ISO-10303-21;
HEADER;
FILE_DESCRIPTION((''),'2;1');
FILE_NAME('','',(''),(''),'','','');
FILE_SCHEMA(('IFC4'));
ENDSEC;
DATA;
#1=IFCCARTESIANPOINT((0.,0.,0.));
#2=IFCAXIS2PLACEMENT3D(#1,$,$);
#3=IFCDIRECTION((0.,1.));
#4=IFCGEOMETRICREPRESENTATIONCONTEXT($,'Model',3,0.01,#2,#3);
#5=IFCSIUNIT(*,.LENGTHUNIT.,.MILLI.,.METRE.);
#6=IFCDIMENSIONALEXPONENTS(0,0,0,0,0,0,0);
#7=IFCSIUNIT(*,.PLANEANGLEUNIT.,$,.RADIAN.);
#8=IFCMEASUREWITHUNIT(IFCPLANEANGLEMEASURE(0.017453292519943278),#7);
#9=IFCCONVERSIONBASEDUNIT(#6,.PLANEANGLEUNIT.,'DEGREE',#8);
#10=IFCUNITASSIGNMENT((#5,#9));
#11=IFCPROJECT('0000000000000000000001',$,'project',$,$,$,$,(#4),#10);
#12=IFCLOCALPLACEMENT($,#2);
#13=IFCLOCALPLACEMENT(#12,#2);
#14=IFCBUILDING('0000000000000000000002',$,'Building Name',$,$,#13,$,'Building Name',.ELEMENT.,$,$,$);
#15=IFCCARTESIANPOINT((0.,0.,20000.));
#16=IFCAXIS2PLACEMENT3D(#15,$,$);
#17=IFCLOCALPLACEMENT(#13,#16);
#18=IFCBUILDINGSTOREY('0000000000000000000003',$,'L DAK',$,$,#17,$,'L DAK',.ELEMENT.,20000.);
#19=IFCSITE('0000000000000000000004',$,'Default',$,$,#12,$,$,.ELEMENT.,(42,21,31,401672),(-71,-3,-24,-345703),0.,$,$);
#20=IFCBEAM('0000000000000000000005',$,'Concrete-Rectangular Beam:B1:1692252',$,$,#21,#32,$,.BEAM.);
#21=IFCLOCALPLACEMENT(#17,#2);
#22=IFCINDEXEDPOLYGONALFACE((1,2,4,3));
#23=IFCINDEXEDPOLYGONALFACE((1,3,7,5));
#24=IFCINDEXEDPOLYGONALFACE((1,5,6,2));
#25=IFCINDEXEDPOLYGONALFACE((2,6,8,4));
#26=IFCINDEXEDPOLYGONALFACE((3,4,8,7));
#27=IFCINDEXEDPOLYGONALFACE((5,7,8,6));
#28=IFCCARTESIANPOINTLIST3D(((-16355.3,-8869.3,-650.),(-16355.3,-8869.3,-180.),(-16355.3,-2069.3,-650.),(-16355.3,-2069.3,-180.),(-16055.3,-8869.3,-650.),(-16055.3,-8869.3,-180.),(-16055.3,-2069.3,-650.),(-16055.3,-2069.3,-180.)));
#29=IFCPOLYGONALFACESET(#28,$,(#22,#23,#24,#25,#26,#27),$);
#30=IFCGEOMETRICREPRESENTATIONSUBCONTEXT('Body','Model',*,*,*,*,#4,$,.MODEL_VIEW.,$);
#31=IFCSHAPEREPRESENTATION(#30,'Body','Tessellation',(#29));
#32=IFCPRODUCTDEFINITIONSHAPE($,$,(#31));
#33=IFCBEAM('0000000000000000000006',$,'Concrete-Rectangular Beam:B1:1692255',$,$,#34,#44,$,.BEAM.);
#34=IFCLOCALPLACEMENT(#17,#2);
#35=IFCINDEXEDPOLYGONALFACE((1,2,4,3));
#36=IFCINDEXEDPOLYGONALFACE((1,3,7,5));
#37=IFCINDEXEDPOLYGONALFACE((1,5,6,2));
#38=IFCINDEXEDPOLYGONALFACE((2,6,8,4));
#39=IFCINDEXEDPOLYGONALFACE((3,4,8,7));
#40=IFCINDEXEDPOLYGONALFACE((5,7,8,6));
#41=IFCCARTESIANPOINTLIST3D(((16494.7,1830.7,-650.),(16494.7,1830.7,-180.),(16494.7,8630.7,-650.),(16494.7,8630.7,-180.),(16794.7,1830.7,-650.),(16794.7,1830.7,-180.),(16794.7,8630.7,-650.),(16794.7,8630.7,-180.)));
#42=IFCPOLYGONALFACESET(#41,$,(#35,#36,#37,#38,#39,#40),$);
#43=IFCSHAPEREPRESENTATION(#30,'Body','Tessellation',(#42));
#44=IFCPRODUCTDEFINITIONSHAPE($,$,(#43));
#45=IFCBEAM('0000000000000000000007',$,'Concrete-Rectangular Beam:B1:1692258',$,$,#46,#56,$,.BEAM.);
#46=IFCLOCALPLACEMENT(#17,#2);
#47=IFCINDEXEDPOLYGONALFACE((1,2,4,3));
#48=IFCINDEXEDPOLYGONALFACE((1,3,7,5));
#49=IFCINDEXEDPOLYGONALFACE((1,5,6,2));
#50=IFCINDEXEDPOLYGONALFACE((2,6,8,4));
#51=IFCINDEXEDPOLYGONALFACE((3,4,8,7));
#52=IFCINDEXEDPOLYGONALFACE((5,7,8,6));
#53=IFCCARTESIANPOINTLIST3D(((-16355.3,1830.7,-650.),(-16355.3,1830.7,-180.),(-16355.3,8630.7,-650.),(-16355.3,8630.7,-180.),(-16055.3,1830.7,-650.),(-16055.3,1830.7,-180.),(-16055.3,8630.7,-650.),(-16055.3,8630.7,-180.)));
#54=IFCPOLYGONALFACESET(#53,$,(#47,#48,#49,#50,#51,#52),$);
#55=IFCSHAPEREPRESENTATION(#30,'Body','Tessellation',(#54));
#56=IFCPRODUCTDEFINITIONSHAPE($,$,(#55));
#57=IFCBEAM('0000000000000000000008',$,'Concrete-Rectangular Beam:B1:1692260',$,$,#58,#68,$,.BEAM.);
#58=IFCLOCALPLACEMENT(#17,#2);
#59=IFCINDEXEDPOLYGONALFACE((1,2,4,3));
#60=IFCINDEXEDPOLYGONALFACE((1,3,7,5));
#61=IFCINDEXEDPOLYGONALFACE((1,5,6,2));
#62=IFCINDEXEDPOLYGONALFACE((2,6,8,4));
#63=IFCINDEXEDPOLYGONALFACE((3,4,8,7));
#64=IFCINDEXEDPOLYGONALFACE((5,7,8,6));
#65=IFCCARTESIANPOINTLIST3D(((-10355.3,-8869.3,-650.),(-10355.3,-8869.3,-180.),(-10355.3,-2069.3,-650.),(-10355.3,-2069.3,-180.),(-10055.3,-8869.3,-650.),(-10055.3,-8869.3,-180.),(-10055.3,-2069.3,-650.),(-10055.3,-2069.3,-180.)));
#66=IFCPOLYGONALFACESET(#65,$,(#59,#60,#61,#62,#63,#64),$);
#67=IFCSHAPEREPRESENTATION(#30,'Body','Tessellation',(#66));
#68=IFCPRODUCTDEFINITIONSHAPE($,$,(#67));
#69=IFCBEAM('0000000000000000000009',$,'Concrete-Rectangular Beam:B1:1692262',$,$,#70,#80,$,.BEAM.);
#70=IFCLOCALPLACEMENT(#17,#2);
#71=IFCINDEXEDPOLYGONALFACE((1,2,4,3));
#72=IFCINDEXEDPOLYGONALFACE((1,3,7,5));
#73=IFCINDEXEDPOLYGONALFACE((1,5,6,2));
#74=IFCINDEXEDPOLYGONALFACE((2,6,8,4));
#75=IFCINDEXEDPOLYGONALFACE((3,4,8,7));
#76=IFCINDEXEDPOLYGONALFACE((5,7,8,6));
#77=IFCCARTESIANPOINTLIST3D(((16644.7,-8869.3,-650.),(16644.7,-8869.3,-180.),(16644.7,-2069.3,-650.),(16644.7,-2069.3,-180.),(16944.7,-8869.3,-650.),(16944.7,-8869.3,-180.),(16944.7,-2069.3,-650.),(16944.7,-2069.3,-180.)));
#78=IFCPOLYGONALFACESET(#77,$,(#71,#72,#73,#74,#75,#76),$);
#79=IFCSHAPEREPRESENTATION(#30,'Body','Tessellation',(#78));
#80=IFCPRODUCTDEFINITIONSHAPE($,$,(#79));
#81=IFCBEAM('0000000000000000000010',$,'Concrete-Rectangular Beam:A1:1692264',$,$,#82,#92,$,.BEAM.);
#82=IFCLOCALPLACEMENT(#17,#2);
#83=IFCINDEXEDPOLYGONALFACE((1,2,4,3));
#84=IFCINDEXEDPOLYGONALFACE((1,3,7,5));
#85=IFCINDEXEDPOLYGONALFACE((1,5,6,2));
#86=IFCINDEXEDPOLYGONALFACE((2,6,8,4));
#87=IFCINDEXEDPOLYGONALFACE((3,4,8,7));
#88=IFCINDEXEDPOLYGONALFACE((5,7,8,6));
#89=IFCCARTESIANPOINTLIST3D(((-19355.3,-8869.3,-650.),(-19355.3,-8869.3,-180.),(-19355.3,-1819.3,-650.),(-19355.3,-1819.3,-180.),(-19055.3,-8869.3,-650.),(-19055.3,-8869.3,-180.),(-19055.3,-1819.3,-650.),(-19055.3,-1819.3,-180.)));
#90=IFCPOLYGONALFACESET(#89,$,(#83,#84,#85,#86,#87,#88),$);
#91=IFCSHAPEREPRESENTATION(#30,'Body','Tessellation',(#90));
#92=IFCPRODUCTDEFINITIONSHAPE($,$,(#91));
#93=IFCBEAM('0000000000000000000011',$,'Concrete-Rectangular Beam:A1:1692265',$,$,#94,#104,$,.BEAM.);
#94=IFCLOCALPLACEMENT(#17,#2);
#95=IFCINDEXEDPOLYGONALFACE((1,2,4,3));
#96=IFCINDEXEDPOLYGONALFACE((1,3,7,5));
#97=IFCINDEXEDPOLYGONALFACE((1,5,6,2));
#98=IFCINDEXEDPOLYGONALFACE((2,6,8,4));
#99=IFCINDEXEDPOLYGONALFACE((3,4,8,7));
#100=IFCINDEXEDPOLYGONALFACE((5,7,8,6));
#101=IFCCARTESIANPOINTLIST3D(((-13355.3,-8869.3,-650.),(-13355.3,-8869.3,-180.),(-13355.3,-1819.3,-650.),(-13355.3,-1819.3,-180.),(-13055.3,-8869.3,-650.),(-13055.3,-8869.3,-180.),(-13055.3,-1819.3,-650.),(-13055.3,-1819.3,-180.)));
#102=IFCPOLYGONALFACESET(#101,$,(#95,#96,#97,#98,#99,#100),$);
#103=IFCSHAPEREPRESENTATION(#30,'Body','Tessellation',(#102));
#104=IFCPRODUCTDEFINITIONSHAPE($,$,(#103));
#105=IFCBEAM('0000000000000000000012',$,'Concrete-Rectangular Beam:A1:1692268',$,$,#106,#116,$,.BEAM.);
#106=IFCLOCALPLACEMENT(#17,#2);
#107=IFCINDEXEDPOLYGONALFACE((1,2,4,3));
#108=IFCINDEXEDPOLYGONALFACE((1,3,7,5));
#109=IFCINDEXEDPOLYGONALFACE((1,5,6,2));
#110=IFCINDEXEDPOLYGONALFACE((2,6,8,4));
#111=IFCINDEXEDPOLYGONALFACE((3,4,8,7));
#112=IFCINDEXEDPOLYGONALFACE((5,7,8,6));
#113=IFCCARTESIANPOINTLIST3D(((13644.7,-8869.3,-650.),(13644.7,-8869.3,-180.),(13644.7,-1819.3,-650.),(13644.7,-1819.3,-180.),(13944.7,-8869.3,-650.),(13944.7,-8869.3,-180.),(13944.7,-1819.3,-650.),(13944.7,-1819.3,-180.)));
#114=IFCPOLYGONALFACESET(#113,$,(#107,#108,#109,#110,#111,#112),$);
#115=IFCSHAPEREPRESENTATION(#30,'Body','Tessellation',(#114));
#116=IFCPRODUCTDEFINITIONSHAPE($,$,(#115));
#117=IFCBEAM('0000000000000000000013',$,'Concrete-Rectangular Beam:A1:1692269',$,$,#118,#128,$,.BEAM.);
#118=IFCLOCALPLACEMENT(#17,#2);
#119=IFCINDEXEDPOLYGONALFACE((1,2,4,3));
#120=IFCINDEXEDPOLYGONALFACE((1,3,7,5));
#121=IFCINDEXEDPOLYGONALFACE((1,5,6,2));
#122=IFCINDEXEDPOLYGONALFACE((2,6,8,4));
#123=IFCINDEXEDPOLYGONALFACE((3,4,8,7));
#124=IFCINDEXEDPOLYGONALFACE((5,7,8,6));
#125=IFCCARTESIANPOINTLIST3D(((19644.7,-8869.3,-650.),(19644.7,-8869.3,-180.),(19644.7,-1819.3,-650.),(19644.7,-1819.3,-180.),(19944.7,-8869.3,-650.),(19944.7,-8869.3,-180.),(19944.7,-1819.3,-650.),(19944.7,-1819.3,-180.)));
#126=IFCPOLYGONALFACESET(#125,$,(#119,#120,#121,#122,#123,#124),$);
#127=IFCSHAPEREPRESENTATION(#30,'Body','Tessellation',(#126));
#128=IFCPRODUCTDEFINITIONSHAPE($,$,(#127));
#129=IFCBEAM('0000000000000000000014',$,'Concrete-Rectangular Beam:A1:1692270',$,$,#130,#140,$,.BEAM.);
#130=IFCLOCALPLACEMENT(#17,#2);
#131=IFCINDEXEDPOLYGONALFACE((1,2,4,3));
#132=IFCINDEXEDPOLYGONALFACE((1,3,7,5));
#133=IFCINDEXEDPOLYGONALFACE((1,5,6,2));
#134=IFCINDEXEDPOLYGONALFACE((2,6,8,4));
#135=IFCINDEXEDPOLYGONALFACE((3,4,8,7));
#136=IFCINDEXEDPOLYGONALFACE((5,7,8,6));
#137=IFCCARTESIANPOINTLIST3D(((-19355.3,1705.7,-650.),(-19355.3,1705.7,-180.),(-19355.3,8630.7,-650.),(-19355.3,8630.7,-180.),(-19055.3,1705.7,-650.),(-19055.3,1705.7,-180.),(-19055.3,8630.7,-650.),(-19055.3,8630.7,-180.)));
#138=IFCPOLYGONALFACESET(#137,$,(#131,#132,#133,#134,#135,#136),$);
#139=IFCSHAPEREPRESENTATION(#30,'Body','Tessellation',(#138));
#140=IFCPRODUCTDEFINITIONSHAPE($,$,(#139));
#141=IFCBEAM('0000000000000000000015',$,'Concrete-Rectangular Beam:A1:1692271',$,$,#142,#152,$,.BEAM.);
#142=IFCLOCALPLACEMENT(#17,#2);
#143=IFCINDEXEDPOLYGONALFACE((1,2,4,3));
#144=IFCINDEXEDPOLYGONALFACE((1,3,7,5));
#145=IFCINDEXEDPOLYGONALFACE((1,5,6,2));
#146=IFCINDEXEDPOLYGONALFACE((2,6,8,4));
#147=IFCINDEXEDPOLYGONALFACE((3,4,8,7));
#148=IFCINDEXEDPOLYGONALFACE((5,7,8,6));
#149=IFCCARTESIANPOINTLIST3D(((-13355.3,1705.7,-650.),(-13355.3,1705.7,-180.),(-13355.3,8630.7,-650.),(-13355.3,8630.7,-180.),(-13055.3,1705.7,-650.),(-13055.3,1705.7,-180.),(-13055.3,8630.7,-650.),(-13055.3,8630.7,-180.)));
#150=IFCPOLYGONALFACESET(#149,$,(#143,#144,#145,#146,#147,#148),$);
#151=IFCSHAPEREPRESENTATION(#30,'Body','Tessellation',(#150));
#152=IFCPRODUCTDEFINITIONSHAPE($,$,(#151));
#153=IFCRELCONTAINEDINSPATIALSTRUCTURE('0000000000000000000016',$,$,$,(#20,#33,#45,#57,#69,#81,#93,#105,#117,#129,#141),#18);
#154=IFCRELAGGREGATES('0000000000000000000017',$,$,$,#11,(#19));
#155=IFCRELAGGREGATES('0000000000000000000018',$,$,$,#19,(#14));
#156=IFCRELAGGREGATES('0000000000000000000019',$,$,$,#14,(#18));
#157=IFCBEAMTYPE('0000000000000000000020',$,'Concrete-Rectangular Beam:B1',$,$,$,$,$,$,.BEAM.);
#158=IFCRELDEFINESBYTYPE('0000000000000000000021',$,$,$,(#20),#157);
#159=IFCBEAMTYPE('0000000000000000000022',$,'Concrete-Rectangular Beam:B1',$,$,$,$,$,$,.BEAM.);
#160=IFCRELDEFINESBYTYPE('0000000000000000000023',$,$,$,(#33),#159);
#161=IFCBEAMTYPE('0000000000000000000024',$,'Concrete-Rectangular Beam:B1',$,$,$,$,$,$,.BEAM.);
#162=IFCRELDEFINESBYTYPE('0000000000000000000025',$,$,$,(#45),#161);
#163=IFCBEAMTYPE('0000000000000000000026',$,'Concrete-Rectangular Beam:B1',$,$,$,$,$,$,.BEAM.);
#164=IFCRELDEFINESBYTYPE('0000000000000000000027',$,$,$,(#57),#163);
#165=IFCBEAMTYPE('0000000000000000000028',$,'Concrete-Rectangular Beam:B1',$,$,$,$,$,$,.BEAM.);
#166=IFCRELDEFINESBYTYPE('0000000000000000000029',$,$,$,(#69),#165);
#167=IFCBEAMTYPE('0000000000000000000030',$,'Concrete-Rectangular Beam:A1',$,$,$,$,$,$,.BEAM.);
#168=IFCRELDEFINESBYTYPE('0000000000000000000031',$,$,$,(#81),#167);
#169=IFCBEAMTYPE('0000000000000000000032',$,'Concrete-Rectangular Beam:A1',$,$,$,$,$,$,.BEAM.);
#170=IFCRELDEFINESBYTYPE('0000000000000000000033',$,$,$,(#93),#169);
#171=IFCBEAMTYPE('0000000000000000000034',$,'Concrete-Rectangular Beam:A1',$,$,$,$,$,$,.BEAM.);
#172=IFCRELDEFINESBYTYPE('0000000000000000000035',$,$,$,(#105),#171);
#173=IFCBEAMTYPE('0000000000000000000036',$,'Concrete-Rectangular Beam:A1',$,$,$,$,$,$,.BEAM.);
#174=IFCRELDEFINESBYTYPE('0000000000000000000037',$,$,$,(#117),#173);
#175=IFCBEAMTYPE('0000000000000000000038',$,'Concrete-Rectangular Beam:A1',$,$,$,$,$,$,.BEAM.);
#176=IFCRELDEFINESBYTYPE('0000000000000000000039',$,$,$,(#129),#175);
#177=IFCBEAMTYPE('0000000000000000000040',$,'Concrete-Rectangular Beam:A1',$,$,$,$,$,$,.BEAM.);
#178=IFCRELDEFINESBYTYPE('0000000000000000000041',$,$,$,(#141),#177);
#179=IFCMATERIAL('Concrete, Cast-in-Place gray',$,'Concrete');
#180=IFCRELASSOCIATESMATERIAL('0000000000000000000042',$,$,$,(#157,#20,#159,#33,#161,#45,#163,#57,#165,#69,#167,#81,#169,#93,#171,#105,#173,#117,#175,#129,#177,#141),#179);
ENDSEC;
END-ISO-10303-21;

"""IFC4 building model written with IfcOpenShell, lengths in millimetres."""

from ifc_helpers import new_model, entity, si_unit, converted_unit, direction, frame, origin, place, context, subcontext, project, spatial, indexed_curve, outline, extrude, source, transform, mapped, material, type_object, type_shapes, element, save


model = new_model("IFC4")

# Units and contexts
model_context = context("Model", 3, precision=0.01, world=origin(), true_north=direction((0.0, 1.0)))
body_context = subcontext(model_context, "Body", "Model", "MODEL_VIEW")
ifc_project = project(units=[si_unit("LENGTHUNIT", "METRE", prefix="MILLI"), converted_unit("PLANEANGLEUNIT", "DEGREE", entity("IfcPlaneAngleMeasure", 0.017453292519943278), si_unit("PLANEANGLEUNIT", "RADIAN"), dimensions=[0, 0, 0, 0, 0, 0, 0])], contexts=[model_context])

# Site, building, storey
site_placement = place(None, origin())
site = spatial("IfcSite", under=ifc_project, at=site_placement, Name="Default", CompositionType="ELEMENT", RefLatitude=(42, 21, 31, 401672), RefLongitude=(-71, -3, -24, -345703), RefElevation=0.0)
building_placement = place(site_placement, origin())
building = spatial("IfcBuilding", under=site, at=building_placement, Name="Building Name", LongName="Building Name", CompositionType="ELEMENT")
storey_placement = place(building_placement, frame((0.0, 0.0, 20000.0)))
storey = spatial("IfcBuildingStorey", under=building, at=storey_placement, Name="L DAK", LongName="L DAK", CompositionType="ELEMENT", Elevation=20000.0)

# Beams
ifc_material = material(Name="Concrete, Cast-in-Place gray", Category="Concrete")
beam_type_1 = type_object("IfcBeamType", Name="Concrete-Rectangular Beam:B1", PredefinedType="BEAM", material=ifc_material)
shared_shape_1 = source(origin(), body_context, "Body", "SweptSolid", [
    extrude(outline(indexed_curve([(-150.0, -235.0), (150.0, -235.0), (150.0, 235.0), (-150.0, 235.0), (-150.0, -235.0)], self_intersect=False)), frame((-16205.3, -2069.3, 19585.0), z_axis=(0.0, -1.0, 0.0), x_axis=(-1.0, 0.0, 0.0)), (0.0, 0.0, 1.0), 6800.0),
])
type_shapes(beam_type_1, [shared_shape_1])
beam_1_placement = place(storey_placement, frame((0.0, 0.0, -20000.0)))
element("IfcBeam", 1, at=beam_1_placement, inside=storey, type_object=beam_type_1, material=ifc_material, Name="Concrete-Rectangular Beam:B1:1692252", PredefinedType="BEAM", context=body_context, shape_type="MappedRepresentation", body=[
    mapped(shared_shape_1, transform((0.0, 0.0, 0.0), scale=1.0)),
])
beam_type_2 = type_object("IfcBeamType", Name="Concrete-Rectangular Beam:B1", PredefinedType="BEAM", material=ifc_material)
shared_shape_2 = source(origin(), body_context, "Body", "SweptSolid", [
    extrude(outline(indexed_curve([(-150.0, -235.0), (150.0, -235.0), (150.0, 235.0), (-150.0, 235.0), (-150.0, -235.0)], self_intersect=False)), frame((16644.7, 8630.7, 19585.0), z_axis=(0.0, -1.0, 0.0), x_axis=(-1.0, 0.0, 0.0)), (0.0, 0.0, 1.0), 6800.0),
])
type_shapes(beam_type_2, [shared_shape_2])
beam_2_placement = place(storey_placement, frame((0.0, 0.0, -20000.0)))
element("IfcBeam", 2, at=beam_2_placement, inside=storey, type_object=beam_type_2, material=ifc_material, Name="Concrete-Rectangular Beam:B1:1692255", PredefinedType="BEAM", context=body_context, shape_type="MappedRepresentation", body=[
    mapped(shared_shape_2, transform((0.0, 0.0, 0.0), scale=1.0)),
])
beam_type_3 = type_object("IfcBeamType", Name="Concrete-Rectangular Beam:B1", PredefinedType="BEAM", material=ifc_material)
shared_shape_3 = source(origin(), body_context, "Body", "SweptSolid", [
    extrude(outline(indexed_curve([(-150.0, -235.0), (150.0, -235.0), (150.0, 235.0), (-150.0, 235.0), (-150.0, -235.0)], self_intersect=False)), frame((-16205.3, 8630.7, 19585.0), z_axis=(0.0, -1.0, 0.0), x_axis=(-1.0, 0.0, 0.0)), (0.0, 0.0, 1.0), 6800.0),
])
type_shapes(beam_type_3, [shared_shape_3])
beam_3_placement = place(storey_placement, frame((0.0, 0.0, -20000.0)))
element("IfcBeam", 3, at=beam_3_placement, inside=storey, type_object=beam_type_3, material=ifc_material, Name="Concrete-Rectangular Beam:B1:1692258", PredefinedType="BEAM", context=body_context, shape_type="MappedRepresentation", body=[
    mapped(shared_shape_3, transform((0.0, 0.0, 0.0), scale=1.0)),
])
beam_type_4 = type_object("IfcBeamType", Name="Concrete-Rectangular Beam:B1", PredefinedType="BEAM", material=ifc_material)
shared_shape_4 = source(origin(), body_context, "Body", "SweptSolid", [
    extrude(outline(indexed_curve([(-150.0, -235.0), (150.0, -235.0), (150.0, 235.0), (-150.0, 235.0), (-150.0, -235.0)], self_intersect=False)), frame((-10205.3, -8869.3, 19585.0), z_axis=(0.0, 1.0, 0.0), x_axis=(-1.0, 0.0, 0.0)), (0.0, 0.0, 1.0), 6800.0),
])
type_shapes(beam_type_4, [shared_shape_4])
beam_4_placement = place(storey_placement, frame((0.0, 0.0, -20000.0)))
element("IfcBeam", 4, at=beam_4_placement, inside=storey, type_object=beam_type_4, material=ifc_material, Name="Concrete-Rectangular Beam:B1:1692260", PredefinedType="BEAM", context=body_context, shape_type="MappedRepresentation", body=[
    mapped(shared_shape_4, transform((0.0, 0.0, 0.0), scale=1.0)),
])
beam_type_5 = type_object("IfcBeamType", Name="Concrete-Rectangular Beam:B1", PredefinedType="BEAM", material=ifc_material)
shared_shape_5 = source(origin(), body_context, "Body", "SweptSolid", [
    extrude(outline(indexed_curve([(-150.0, -235.0), (150.0, -235.0), (150.0, 235.0), (-150.0, 235.0), (-150.0, -235.0)], self_intersect=False)), frame((16794.7, -8869.3, 19585.0), z_axis=(0.0, 1.0, 0.0), x_axis=(-1.0, 0.0, 0.0)), (0.0, 0.0, 1.0), 6800.0),
])
type_shapes(beam_type_5, [shared_shape_5])
beam_5_placement = place(storey_placement, frame((0.0, 0.0, -20000.0)))
element("IfcBeam", 5, at=beam_5_placement, inside=storey, type_object=beam_type_5, material=ifc_material, Name="Concrete-Rectangular Beam:B1:1692262", PredefinedType="BEAM", context=body_context, shape_type="MappedRepresentation", body=[
    mapped(shared_shape_5, transform((0.0, 0.0, 0.0), scale=1.0)),
])
beam_type_6 = type_object("IfcBeamType", Name="Concrete-Rectangular Beam:A1", PredefinedType="BEAM", material=ifc_material)
shared_shape_6 = source(origin(), body_context, "Body", "SweptSolid", [
    extrude(outline(indexed_curve([(-150.0, -235.0), (150.0, -235.0), (150.0, 235.0), (-150.0, 235.0), (-150.0, -235.0)], self_intersect=False)), frame((-19205.3, -8869.3, 19585.0), z_axis=(0.0, 1.0, 0.0), x_axis=(-1.0, 0.0, 0.0)), (0.0, 0.0, 1.0), 7050.0),
])
type_shapes(beam_type_6, [shared_shape_6])
beam_6_placement = place(storey_placement, frame((0.0, 0.0, -20000.0)))
element("IfcBeam", 6, at=beam_6_placement, inside=storey, type_object=beam_type_6, material=ifc_material, Name="Concrete-Rectangular Beam:A1:1692264", PredefinedType="BEAM", context=body_context, shape_type="MappedRepresentation", body=[
    mapped(shared_shape_6, transform((0.0, 0.0, 0.0), scale=1.0)),
])
beam_type_7 = type_object("IfcBeamType", Name="Concrete-Rectangular Beam:A1", PredefinedType="BEAM", material=ifc_material)
shared_shape_7 = source(origin(), body_context, "Body", "SweptSolid", [
    extrude(outline(indexed_curve([(-150.0, -235.0), (150.0, -235.0), (150.0, 235.0), (-150.0, 235.0), (-150.0, -235.0)], self_intersect=False)), frame((-13205.3, -8869.3, 19585.0), z_axis=(0.0, 1.0, 0.0), x_axis=(-1.0, 0.0, 0.0)), (0.0, 0.0, 1.0), 7050.0),
])
type_shapes(beam_type_7, [shared_shape_7])
beam_7_placement = place(storey_placement, frame((0.0, 0.0, -20000.0)))
element("IfcBeam", 7, at=beam_7_placement, inside=storey, type_object=beam_type_7, material=ifc_material, Name="Concrete-Rectangular Beam:A1:1692265", PredefinedType="BEAM", context=body_context, shape_type="MappedRepresentation", body=[
    mapped(shared_shape_7, transform((0.0, 0.0, 0.0), scale=1.0)),
])
beam_type_8 = type_object("IfcBeamType", Name="Concrete-Rectangular Beam:A1", PredefinedType="BEAM", material=ifc_material)
shared_shape_8 = source(origin(), body_context, "Body", "SweptSolid", [
    extrude(outline(indexed_curve([(-150.0, -235.0), (150.0, -235.0), (150.0, 235.0), (-150.0, 235.0), (-150.0, -235.0)], self_intersect=False)), frame((13794.7, -8869.3, 19585.0), z_axis=(0.0, 1.0, 0.0), x_axis=(-1.0, 0.0, 0.0)), (0.0, 0.0, 1.0), 7050.0),
])
type_shapes(beam_type_8, [shared_shape_8])
beam_8_placement = place(storey_placement, frame((0.0, 0.0, -20000.0)))
element("IfcBeam", 8, at=beam_8_placement, inside=storey, type_object=beam_type_8, material=ifc_material, Name="Concrete-Rectangular Beam:A1:1692268", PredefinedType="BEAM", context=body_context, shape_type="MappedRepresentation", body=[
    mapped(shared_shape_8, transform((0.0, 0.0, 0.0), scale=1.0)),
])
beam_type_9 = type_object("IfcBeamType", Name="Concrete-Rectangular Beam:A1", PredefinedType="BEAM", material=ifc_material)
shared_shape_9 = source(origin(), body_context, "Body", "SweptSolid", [
    extrude(outline(indexed_curve([(-150.0, -235.0), (150.0, -235.0), (150.0, 235.0), (-150.0, 235.0), (-150.0, -235.0)], self_intersect=False)), frame((19794.7, -8869.3, 19585.0), z_axis=(0.0, 1.0, 0.0), x_axis=(-1.0, 0.0, 0.0)), (0.0, 0.0, 1.0), 7050.0),
])
type_shapes(beam_type_9, [shared_shape_9])
beam_9_placement = place(storey_placement, frame((0.0, 0.0, -20000.0)))
element("IfcBeam", 9, at=beam_9_placement, inside=storey, type_object=beam_type_9, material=ifc_material, Name="Concrete-Rectangular Beam:A1:1692269", PredefinedType="BEAM", context=body_context, shape_type="MappedRepresentation", body=[
    mapped(shared_shape_9, transform((0.0, 0.0, 0.0), scale=1.0)),
])
beam_type_10 = type_object("IfcBeamType", Name="Concrete-Rectangular Beam:A1", PredefinedType="BEAM", material=ifc_material)
shared_shape_10 = source(origin(), body_context, "Body", "SweptSolid", [
    extrude(outline(indexed_curve([(-150.0, -235.0), (150.0, -235.0), (150.0, 235.0), (-150.0, 235.0), (-150.0, -235.0)], self_intersect=False)), frame((-19205.3, 8630.7, 19585.0), z_axis=(0.0, -1.0, 0.0), x_axis=(-1.0, 0.0, 0.0)), (0.0, 0.0, 1.0), 6925.0),
])
type_shapes(beam_type_10, [shared_shape_10])
beam_10_placement = place(storey_placement, frame((0.0, 0.0, -20000.0)))
element("IfcBeam", 10, at=beam_10_placement, inside=storey, type_object=beam_type_10, material=ifc_material, Name="Concrete-Rectangular Beam:A1:1692270", PredefinedType="BEAM", context=body_context, shape_type="MappedRepresentation", body=[
    mapped(shared_shape_10, transform((0.0, 0.0, 0.0), scale=1.0)),
])
beam_type_11 = type_object("IfcBeamType", Name="Concrete-Rectangular Beam:A1", PredefinedType="BEAM", material=ifc_material)
shared_shape_11 = source(origin(), body_context, "Body", "SweptSolid", [
    extrude(outline(indexed_curve([(-150.0, -235.0), (150.0, -235.0), (150.0, 235.0), (-150.0, 235.0), (-150.0, -235.0)], self_intersect=False)), frame((-13205.3, 8630.7, 19585.0), z_axis=(0.0, -1.0, 0.0), x_axis=(-1.0, 0.0, 0.0)), (0.0, 0.0, 1.0), 6925.0),
])
type_shapes(beam_type_11, [shared_shape_11])
beam_11_placement = place(storey_placement, frame((0.0, 0.0, -20000.0)))
element("IfcBeam", 11, at=beam_11_placement, inside=storey, type_object=beam_type_11, material=ifc_material, Name="Concrete-Rectangular Beam:A1:1692271", PredefinedType="BEAM", context=body_context, shape_type="MappedRepresentation", body=[
    mapped(shared_shape_11, transform((0.0, 0.0, 0.0), scale=1.0)),
])

save(model, "model.ifc")
